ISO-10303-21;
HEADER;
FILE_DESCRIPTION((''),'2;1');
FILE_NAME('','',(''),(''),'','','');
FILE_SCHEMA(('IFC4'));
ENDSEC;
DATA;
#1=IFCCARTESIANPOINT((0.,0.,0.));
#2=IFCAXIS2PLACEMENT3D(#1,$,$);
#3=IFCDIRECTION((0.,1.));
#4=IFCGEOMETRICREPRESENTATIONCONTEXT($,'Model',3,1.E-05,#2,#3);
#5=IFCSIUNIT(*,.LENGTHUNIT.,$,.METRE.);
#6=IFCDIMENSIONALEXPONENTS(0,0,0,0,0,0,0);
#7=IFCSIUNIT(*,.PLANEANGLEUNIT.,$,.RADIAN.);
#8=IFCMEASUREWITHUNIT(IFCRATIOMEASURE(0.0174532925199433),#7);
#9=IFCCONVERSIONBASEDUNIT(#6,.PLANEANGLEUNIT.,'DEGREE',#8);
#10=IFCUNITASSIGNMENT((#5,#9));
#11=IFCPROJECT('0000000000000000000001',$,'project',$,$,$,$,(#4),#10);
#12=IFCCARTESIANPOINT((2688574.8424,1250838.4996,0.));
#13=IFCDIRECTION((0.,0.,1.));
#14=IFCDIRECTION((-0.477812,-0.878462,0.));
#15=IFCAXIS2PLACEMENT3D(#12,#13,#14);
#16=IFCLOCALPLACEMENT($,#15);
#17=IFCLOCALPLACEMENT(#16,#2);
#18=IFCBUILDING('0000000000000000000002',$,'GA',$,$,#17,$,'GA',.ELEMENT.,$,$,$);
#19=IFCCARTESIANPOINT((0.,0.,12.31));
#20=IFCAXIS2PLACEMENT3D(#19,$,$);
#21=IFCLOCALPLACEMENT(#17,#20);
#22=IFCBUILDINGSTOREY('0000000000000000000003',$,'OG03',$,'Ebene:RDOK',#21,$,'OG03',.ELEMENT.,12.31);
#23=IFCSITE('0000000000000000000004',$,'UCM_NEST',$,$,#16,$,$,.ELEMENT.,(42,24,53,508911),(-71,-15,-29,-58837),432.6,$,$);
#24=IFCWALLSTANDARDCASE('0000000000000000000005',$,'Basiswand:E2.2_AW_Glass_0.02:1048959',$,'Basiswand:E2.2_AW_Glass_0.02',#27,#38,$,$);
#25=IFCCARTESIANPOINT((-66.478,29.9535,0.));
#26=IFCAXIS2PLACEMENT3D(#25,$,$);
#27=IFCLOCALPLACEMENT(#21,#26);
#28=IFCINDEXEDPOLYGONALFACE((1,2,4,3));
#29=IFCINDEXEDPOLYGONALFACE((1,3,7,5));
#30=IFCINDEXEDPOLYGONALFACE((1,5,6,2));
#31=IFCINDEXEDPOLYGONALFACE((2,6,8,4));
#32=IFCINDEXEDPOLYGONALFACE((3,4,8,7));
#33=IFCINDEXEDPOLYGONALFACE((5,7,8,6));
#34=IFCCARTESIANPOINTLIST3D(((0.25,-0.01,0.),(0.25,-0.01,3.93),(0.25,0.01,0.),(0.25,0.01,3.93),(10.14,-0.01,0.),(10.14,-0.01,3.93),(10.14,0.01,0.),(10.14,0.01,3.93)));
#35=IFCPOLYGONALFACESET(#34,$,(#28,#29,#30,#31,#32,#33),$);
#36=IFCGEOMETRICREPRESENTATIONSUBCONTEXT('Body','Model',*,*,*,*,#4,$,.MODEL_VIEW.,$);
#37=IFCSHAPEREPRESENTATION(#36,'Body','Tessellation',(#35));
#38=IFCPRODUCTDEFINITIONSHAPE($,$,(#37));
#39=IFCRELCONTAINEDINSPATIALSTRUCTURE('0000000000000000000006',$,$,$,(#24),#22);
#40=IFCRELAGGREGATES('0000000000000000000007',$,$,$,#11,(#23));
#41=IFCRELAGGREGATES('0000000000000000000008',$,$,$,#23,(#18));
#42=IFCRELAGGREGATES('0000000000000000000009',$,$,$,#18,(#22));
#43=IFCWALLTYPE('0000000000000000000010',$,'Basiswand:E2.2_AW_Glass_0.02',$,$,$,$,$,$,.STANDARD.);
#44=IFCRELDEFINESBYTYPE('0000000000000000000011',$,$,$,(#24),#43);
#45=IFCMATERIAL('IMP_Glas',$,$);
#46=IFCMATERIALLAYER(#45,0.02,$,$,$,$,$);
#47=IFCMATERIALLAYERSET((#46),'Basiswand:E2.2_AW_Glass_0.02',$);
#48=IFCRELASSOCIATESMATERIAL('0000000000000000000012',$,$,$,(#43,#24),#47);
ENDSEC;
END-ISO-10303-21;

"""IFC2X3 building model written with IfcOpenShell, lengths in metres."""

from ifc_helpers import new_model, entity, si_unit, converted_unit, direction, frame, frame_2d, origin, place, context, subcontext, project, spatial, rectangle, extrude, material, layer, layer_set, layer_usage, type_object, element, save


model = new_model("IFC2X3")

# Units and contexts
model_context = context("Model", 3, precision=1e-05, world=origin(), true_north=direction((0.0, 1.0)))
body_context = subcontext(model_context, "Body", "Model", "MODEL_VIEW")
ifc_project = project(units=[si_unit("LENGTHUNIT", "METRE"), converted_unit("PLANEANGLEUNIT", "DEGREE", entity("IfcRatioMeasure", 0.0174532925199433), si_unit("PLANEANGLEUNIT", "RADIAN"), dimensions=[0, 0, 0, 0, 0, 0, 0])], contexts=[model_context])

# Site, building, storey
site_placement = place(None, frame((2688574.8424, 1250838.4996, 0.0), z_axis=(0.0, 0.0, 1.0), x_axis=(-0.477812, -0.878462, 0.0)))
site = spatial("IfcSite", under=ifc_project, at=site_placement, Name="UCM_NEST", CompositionType="ELEMENT", RefLatitude=(42, 24, 53, 508911), RefLongitude=(-71, -15, -29, -58837), RefElevation=432.6)
building_placement = place(site_placement, origin())
building = spatial("IfcBuilding", under=site, at=building_placement, Name="GA", LongName="GA", CompositionType="ELEMENT")
storey_placement = place(building_placement, frame((0.0, 0.0, 12.31)))
storey = spatial("IfcBuildingStorey", under=building, at=storey_placement, Name="OG03", ObjectType="Ebene:RDOK", LongName="OG03", CompositionType="ELEMENT", Elevation=12.31)

# Wall
ifc_material_1 = material(Name="IMP_Glas")
ifc_layer_1 = layer(ifc_material_1, 0.02)
ifc_layer_set_1 = layer_set([ifc_layer_1], Name="Basiswand:E2.2_AW_Glass_0.02")
ifc_layer_usage_1 = layer_usage(ifc_layer_set_1, "AXIS2", "NEGATIVE", 0.01)
wall_type_1 = type_object("IfcWallType", Name="Basiswand:E2.2_AW_Glass_0.02", PredefinedType="STANDARD", material=ifc_layer_set_1)
wall_1_placement = place(storey_placement, frame((-66.478, 29.9535, 0.0)))
element("IfcWallStandardCase", 1, at=wall_1_placement, inside=storey, type_object=wall_type_1, material=ifc_layer_usage_1, Name="Basiswand:E2.2_AW_Glass_0.02:1048959", ObjectType="Basiswand:E2.2_AW_Glass_0.02", context=body_context, shape_type="SweptSolid", body=[
    extrude(rectangle(XDim=9.89, YDim=0.02, at=frame_2d((5.195, 0.0), x_axis=(-1.0, 0.0))), origin(), (0.0, 0.0, 1.0), 3.93),
])

save(model, "model.ifc")
